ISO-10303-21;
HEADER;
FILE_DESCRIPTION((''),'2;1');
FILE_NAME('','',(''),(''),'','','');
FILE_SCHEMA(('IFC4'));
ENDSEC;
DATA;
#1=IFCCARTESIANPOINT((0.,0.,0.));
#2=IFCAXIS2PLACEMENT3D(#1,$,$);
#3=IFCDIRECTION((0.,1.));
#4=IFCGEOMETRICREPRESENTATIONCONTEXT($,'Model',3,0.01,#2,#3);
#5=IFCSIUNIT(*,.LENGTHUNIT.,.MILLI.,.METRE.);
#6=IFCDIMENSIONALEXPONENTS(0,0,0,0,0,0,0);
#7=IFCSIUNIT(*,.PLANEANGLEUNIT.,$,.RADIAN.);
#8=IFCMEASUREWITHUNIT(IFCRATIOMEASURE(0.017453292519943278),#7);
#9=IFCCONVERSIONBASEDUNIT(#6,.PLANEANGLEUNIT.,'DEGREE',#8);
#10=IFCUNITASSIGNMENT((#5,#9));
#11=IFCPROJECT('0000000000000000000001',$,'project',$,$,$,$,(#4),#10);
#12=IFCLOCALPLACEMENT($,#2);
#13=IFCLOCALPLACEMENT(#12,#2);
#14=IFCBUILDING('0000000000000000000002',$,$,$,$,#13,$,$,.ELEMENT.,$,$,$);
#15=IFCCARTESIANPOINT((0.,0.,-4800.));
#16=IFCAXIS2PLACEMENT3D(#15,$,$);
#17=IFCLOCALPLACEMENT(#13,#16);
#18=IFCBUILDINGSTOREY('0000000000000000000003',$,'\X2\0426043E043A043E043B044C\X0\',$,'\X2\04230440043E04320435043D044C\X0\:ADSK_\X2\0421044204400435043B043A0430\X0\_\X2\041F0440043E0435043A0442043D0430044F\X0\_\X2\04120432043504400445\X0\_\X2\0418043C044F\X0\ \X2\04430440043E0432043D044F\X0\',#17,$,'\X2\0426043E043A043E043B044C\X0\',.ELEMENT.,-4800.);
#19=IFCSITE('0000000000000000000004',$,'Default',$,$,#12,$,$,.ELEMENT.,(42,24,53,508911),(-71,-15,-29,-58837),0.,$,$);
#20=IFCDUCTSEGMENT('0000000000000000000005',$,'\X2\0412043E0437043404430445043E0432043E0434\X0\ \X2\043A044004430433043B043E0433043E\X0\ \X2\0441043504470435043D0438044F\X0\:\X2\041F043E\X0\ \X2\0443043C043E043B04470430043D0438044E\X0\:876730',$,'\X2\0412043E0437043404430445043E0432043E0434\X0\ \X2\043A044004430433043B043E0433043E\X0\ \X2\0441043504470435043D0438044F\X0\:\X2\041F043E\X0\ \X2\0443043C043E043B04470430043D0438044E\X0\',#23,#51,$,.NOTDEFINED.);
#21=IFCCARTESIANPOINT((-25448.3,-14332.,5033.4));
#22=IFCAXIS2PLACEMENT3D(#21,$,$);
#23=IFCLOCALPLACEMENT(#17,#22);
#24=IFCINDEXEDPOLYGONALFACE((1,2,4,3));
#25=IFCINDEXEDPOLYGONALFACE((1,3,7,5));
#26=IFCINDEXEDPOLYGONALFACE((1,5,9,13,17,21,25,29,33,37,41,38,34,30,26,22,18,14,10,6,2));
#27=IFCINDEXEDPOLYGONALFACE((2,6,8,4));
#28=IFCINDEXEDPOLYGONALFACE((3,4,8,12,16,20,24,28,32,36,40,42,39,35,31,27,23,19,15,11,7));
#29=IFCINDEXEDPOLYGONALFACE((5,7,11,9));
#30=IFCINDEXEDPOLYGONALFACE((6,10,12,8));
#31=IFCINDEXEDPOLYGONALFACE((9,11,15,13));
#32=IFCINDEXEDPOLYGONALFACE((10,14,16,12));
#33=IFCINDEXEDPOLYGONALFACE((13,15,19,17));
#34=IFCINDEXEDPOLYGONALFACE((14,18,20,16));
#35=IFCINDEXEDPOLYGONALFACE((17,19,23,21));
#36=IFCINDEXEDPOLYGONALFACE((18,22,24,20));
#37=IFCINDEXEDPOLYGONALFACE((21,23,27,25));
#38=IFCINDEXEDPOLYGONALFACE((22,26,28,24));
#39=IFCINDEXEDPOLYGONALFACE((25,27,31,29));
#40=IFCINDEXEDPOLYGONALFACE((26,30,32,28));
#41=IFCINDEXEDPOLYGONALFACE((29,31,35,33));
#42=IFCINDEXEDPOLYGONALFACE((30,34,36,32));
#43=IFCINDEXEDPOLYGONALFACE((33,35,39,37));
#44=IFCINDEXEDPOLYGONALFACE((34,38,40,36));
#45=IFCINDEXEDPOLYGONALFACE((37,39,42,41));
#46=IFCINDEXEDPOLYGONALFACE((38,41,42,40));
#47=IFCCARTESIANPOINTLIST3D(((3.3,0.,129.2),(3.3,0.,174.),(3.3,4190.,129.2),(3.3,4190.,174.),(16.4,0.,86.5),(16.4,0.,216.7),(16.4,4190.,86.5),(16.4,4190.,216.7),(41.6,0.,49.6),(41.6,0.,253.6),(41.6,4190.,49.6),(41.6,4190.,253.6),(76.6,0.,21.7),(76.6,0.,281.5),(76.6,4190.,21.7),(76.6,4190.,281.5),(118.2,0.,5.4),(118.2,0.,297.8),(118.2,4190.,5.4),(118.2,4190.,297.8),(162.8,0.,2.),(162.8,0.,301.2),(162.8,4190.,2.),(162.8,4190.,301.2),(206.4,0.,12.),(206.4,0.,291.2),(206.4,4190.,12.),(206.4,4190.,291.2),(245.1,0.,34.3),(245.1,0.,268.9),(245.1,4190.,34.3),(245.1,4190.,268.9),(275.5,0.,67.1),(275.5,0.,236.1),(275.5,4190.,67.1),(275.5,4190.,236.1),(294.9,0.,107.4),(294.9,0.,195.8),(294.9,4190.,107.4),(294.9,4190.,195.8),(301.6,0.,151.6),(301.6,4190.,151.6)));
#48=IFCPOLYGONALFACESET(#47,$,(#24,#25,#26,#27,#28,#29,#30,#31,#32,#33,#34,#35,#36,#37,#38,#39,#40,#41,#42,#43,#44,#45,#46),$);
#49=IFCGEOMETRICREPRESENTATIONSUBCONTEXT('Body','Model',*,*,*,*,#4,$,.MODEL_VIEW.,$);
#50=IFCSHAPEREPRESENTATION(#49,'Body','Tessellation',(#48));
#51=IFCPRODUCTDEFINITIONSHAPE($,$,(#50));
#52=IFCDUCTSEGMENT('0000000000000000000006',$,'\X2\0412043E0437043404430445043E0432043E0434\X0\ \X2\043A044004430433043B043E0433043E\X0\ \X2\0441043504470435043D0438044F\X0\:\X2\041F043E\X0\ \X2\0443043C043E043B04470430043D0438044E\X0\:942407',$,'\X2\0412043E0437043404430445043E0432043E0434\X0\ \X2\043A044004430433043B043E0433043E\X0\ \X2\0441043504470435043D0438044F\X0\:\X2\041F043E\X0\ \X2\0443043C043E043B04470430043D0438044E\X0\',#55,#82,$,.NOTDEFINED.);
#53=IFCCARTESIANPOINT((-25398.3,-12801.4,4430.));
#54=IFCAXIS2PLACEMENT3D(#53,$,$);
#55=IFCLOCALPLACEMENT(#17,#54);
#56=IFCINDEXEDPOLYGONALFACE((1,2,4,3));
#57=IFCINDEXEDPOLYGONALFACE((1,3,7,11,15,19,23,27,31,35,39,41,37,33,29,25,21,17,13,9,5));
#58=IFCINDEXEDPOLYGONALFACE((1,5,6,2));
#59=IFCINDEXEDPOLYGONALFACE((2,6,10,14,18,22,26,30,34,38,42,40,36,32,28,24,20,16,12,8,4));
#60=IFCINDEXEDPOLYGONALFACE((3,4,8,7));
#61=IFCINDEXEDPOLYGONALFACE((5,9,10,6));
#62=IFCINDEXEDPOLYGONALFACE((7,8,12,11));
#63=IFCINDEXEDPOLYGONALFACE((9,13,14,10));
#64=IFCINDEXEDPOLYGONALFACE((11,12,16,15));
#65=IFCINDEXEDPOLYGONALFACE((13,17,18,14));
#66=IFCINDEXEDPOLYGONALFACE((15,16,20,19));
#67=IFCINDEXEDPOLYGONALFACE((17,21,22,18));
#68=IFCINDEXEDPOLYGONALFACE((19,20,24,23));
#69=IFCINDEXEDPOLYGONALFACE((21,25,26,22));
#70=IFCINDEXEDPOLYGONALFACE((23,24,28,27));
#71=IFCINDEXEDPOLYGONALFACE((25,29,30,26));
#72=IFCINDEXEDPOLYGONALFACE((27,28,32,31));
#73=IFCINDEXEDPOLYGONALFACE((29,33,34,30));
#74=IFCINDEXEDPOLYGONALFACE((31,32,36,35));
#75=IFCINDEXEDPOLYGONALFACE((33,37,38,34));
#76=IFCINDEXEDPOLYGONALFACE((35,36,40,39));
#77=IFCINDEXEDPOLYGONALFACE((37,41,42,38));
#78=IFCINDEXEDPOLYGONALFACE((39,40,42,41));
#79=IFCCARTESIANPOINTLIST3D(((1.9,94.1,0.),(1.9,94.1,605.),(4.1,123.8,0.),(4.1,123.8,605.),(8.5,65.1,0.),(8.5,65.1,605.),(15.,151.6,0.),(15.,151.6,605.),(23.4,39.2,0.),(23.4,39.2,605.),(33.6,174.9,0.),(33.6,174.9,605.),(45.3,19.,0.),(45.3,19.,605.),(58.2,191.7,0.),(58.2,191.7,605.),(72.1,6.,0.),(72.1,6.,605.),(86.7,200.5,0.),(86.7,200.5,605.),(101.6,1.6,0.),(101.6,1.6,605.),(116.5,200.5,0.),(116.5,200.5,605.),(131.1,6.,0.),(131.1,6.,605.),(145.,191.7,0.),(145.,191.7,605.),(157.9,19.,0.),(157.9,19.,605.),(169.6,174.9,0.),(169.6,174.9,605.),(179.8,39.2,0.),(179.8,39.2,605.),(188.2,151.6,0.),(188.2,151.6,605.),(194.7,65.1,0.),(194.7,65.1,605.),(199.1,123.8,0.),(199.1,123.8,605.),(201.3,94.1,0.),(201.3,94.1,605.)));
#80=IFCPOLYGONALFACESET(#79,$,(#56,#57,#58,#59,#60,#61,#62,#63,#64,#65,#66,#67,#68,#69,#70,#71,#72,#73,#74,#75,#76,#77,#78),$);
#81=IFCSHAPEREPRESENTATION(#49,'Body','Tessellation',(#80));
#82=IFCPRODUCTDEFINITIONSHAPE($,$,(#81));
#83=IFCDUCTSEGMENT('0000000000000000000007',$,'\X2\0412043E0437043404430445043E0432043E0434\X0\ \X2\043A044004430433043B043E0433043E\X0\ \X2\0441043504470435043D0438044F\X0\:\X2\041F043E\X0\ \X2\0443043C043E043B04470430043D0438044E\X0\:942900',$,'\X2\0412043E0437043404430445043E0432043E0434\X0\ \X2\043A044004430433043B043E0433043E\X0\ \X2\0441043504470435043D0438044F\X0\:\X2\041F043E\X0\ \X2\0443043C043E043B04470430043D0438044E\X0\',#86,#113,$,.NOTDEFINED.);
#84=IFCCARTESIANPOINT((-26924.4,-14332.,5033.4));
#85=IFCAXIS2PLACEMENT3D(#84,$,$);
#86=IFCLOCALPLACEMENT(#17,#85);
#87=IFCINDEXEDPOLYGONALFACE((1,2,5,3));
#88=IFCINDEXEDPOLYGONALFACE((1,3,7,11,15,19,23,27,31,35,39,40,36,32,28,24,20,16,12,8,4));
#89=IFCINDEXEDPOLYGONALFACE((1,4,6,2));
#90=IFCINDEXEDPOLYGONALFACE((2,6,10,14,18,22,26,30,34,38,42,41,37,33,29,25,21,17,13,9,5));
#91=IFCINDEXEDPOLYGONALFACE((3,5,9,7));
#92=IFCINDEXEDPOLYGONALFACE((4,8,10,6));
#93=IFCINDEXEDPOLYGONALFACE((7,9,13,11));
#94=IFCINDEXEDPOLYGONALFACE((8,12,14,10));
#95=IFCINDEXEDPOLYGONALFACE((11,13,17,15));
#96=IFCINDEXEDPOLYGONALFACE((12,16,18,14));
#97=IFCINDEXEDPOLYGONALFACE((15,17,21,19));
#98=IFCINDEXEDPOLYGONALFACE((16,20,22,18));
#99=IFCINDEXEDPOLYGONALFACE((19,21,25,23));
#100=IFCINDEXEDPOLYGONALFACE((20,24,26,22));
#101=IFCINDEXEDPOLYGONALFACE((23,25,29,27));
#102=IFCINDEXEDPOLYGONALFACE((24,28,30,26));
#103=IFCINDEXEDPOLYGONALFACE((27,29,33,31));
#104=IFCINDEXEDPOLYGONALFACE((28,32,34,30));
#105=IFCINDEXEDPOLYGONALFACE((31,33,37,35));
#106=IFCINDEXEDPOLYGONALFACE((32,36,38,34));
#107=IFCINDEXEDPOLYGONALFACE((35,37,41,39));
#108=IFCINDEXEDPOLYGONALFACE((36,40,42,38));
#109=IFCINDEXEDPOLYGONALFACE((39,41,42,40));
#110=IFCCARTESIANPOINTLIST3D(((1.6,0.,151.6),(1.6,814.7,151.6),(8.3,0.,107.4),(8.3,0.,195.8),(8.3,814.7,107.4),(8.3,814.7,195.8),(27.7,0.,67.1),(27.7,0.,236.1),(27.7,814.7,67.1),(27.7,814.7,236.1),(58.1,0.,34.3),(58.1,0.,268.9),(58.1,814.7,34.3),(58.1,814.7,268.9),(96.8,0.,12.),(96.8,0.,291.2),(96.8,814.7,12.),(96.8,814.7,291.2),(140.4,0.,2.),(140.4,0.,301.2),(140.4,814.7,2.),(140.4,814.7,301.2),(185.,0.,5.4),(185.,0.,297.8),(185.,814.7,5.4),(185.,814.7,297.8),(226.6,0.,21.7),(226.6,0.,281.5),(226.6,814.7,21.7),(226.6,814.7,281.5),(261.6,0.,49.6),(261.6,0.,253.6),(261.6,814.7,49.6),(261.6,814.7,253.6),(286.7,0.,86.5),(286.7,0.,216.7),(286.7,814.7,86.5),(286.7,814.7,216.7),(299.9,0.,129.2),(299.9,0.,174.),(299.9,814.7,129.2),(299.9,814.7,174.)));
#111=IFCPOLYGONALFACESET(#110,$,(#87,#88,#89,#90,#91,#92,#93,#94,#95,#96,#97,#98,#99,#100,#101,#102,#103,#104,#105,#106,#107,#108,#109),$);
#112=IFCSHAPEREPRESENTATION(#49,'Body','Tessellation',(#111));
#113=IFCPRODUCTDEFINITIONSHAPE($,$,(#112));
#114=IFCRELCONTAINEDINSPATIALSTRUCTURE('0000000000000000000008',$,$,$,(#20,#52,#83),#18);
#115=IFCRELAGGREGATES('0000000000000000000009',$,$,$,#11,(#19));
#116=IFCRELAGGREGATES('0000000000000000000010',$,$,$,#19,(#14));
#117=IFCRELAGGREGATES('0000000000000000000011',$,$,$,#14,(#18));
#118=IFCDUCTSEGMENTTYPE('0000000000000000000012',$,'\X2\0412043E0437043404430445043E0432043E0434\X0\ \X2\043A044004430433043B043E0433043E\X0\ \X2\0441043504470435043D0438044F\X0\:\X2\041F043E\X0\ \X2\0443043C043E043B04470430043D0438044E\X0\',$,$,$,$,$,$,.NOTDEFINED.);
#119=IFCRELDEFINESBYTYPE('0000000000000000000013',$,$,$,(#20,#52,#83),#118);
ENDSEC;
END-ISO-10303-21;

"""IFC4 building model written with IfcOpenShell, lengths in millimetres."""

from ifc_helpers import new_model, entity, si_unit, converted_unit, direction, frame, frame_2d, origin, origin_2d_with_axis, place, context, subcontext, project, spatial, circle, extrude, type_object, element, save


model = new_model("IFC4")

# Units and contexts
model_context = context("Model", 3, precision=0.01, world=origin(), true_north=direction((0.0, 1.0)))
body_context = subcontext(model_context, "Body", "Model", "MODEL_VIEW")
ifc_project = project(units=[si_unit("LENGTHUNIT", "METRE", prefix="MILLI"), converted_unit("PLANEANGLEUNIT", "DEGREE", entity("IfcRatioMeasure", 0.017453292519943278), si_unit("PLANEANGLEUNIT", "RADIAN"), dimensions=[0, 0, 0, 0, 0, 0, 0])], contexts=[model_context])

# Site, building, storey
site_placement = place(None, origin())
site = spatial("IfcSite", under=ifc_project, at=site_placement, Name="Default", CompositionType="ELEMENT", RefLatitude=(42, 24, 53, 508911), RefLongitude=(-71, -15, -29, -58837), RefElevation=0.0)
building_placement = place(site_placement, origin())
building = spatial("IfcBuilding", under=site, at=building_placement, CompositionType="ELEMENT")
storey_placement = place(building_placement, frame((0.0, 0.0, -4800.0)))
storey = spatial("IfcBuildingStorey", under=building, at=storey_placement, Name="Цоколь", ObjectType="Уровень:ADSK_Стрелка_Проектная_Вверх_Имя уровня", LongName="Цоколь", CompositionType="ELEMENT", Elevation=-4800.0)

# Duct segments
duct_segment_type = type_object("IfcDuctSegmentType", Name="Воздуховод круглого сечения:По умолчанию", PredefinedType="NOTDEFINED")
duct_segment_1_placement = place(storey_placement, frame((-25448.3, -14332.0, 5033.4)))
element("IfcDuctSegment", 1, at=duct_segment_1_placement, inside=storey, type_object=duct_segment_type, Name="Воздуховод круглого сечения:По умолчанию:876730", ObjectType="Воздуховод круглого сечения:По умолчанию", PredefinedType="NOTDEFINED", context=body_context, shape_type="SweptSolid", body=[
    extrude(circle(Radius=150.0, at=frame_2d((0.0, 0.0), x_axis=(1.0, 0.0))), frame((151.6, 0.0, 151.6), z_axis=(0.0, 1.0, 0.0), x_axis=(1.0, 0.0, 0.0)), (0.0, 0.0, 1.0), 4190.0),
])
duct_segment_2_placement = place(storey_placement, frame((-25398.3, -12801.4, 4430.0)))
element("IfcDuctSegment", 2, at=duct_segment_2_placement, inside=storey, type_object=duct_segment_type, Name="Воздуховод круглого сечения:По умолчанию:942407", ObjectType="Воздуховод круглого сечения:По умолчанию", PredefinedType="NOTDEFINED", context=body_context, shape_type="SweptSolid", body=[
    extrude(circle(Radius=100.0, at=origin_2d_with_axis()), frame((101.6, 101.6, 0.0), z_axis=(0.0, 0.0, 1.0), x_axis=(0.0, -1.0, 0.0)), (0.0, 0.0, 1.0), 605.0),
])
duct_segment_3_placement = place(storey_placement, frame((-26924.4, -14332.0, 5033.4)))
element("IfcDuctSegment", 3, at=duct_segment_3_placement, inside=storey, type_object=duct_segment_type, Name="Воздуховод круглого сечения:По умолчанию:942900", ObjectType="Воздуховод круглого сечения:По умолчанию", PredefinedType="NOTDEFINED", context=body_context, shape_type="SweptSolid", body=[
    extrude(circle(Radius=150.0, at=frame_2d((0.0, 0.0), x_axis=(1.0, 0.0))), frame((151.6, 0.0, 151.6), z_axis=(0.0, 1.0, 0.0), x_axis=(-1.0, 0.0, 0.0)), (0.0, 0.0, 1.0), 814.7),
])

save(model, "model.ifc")
